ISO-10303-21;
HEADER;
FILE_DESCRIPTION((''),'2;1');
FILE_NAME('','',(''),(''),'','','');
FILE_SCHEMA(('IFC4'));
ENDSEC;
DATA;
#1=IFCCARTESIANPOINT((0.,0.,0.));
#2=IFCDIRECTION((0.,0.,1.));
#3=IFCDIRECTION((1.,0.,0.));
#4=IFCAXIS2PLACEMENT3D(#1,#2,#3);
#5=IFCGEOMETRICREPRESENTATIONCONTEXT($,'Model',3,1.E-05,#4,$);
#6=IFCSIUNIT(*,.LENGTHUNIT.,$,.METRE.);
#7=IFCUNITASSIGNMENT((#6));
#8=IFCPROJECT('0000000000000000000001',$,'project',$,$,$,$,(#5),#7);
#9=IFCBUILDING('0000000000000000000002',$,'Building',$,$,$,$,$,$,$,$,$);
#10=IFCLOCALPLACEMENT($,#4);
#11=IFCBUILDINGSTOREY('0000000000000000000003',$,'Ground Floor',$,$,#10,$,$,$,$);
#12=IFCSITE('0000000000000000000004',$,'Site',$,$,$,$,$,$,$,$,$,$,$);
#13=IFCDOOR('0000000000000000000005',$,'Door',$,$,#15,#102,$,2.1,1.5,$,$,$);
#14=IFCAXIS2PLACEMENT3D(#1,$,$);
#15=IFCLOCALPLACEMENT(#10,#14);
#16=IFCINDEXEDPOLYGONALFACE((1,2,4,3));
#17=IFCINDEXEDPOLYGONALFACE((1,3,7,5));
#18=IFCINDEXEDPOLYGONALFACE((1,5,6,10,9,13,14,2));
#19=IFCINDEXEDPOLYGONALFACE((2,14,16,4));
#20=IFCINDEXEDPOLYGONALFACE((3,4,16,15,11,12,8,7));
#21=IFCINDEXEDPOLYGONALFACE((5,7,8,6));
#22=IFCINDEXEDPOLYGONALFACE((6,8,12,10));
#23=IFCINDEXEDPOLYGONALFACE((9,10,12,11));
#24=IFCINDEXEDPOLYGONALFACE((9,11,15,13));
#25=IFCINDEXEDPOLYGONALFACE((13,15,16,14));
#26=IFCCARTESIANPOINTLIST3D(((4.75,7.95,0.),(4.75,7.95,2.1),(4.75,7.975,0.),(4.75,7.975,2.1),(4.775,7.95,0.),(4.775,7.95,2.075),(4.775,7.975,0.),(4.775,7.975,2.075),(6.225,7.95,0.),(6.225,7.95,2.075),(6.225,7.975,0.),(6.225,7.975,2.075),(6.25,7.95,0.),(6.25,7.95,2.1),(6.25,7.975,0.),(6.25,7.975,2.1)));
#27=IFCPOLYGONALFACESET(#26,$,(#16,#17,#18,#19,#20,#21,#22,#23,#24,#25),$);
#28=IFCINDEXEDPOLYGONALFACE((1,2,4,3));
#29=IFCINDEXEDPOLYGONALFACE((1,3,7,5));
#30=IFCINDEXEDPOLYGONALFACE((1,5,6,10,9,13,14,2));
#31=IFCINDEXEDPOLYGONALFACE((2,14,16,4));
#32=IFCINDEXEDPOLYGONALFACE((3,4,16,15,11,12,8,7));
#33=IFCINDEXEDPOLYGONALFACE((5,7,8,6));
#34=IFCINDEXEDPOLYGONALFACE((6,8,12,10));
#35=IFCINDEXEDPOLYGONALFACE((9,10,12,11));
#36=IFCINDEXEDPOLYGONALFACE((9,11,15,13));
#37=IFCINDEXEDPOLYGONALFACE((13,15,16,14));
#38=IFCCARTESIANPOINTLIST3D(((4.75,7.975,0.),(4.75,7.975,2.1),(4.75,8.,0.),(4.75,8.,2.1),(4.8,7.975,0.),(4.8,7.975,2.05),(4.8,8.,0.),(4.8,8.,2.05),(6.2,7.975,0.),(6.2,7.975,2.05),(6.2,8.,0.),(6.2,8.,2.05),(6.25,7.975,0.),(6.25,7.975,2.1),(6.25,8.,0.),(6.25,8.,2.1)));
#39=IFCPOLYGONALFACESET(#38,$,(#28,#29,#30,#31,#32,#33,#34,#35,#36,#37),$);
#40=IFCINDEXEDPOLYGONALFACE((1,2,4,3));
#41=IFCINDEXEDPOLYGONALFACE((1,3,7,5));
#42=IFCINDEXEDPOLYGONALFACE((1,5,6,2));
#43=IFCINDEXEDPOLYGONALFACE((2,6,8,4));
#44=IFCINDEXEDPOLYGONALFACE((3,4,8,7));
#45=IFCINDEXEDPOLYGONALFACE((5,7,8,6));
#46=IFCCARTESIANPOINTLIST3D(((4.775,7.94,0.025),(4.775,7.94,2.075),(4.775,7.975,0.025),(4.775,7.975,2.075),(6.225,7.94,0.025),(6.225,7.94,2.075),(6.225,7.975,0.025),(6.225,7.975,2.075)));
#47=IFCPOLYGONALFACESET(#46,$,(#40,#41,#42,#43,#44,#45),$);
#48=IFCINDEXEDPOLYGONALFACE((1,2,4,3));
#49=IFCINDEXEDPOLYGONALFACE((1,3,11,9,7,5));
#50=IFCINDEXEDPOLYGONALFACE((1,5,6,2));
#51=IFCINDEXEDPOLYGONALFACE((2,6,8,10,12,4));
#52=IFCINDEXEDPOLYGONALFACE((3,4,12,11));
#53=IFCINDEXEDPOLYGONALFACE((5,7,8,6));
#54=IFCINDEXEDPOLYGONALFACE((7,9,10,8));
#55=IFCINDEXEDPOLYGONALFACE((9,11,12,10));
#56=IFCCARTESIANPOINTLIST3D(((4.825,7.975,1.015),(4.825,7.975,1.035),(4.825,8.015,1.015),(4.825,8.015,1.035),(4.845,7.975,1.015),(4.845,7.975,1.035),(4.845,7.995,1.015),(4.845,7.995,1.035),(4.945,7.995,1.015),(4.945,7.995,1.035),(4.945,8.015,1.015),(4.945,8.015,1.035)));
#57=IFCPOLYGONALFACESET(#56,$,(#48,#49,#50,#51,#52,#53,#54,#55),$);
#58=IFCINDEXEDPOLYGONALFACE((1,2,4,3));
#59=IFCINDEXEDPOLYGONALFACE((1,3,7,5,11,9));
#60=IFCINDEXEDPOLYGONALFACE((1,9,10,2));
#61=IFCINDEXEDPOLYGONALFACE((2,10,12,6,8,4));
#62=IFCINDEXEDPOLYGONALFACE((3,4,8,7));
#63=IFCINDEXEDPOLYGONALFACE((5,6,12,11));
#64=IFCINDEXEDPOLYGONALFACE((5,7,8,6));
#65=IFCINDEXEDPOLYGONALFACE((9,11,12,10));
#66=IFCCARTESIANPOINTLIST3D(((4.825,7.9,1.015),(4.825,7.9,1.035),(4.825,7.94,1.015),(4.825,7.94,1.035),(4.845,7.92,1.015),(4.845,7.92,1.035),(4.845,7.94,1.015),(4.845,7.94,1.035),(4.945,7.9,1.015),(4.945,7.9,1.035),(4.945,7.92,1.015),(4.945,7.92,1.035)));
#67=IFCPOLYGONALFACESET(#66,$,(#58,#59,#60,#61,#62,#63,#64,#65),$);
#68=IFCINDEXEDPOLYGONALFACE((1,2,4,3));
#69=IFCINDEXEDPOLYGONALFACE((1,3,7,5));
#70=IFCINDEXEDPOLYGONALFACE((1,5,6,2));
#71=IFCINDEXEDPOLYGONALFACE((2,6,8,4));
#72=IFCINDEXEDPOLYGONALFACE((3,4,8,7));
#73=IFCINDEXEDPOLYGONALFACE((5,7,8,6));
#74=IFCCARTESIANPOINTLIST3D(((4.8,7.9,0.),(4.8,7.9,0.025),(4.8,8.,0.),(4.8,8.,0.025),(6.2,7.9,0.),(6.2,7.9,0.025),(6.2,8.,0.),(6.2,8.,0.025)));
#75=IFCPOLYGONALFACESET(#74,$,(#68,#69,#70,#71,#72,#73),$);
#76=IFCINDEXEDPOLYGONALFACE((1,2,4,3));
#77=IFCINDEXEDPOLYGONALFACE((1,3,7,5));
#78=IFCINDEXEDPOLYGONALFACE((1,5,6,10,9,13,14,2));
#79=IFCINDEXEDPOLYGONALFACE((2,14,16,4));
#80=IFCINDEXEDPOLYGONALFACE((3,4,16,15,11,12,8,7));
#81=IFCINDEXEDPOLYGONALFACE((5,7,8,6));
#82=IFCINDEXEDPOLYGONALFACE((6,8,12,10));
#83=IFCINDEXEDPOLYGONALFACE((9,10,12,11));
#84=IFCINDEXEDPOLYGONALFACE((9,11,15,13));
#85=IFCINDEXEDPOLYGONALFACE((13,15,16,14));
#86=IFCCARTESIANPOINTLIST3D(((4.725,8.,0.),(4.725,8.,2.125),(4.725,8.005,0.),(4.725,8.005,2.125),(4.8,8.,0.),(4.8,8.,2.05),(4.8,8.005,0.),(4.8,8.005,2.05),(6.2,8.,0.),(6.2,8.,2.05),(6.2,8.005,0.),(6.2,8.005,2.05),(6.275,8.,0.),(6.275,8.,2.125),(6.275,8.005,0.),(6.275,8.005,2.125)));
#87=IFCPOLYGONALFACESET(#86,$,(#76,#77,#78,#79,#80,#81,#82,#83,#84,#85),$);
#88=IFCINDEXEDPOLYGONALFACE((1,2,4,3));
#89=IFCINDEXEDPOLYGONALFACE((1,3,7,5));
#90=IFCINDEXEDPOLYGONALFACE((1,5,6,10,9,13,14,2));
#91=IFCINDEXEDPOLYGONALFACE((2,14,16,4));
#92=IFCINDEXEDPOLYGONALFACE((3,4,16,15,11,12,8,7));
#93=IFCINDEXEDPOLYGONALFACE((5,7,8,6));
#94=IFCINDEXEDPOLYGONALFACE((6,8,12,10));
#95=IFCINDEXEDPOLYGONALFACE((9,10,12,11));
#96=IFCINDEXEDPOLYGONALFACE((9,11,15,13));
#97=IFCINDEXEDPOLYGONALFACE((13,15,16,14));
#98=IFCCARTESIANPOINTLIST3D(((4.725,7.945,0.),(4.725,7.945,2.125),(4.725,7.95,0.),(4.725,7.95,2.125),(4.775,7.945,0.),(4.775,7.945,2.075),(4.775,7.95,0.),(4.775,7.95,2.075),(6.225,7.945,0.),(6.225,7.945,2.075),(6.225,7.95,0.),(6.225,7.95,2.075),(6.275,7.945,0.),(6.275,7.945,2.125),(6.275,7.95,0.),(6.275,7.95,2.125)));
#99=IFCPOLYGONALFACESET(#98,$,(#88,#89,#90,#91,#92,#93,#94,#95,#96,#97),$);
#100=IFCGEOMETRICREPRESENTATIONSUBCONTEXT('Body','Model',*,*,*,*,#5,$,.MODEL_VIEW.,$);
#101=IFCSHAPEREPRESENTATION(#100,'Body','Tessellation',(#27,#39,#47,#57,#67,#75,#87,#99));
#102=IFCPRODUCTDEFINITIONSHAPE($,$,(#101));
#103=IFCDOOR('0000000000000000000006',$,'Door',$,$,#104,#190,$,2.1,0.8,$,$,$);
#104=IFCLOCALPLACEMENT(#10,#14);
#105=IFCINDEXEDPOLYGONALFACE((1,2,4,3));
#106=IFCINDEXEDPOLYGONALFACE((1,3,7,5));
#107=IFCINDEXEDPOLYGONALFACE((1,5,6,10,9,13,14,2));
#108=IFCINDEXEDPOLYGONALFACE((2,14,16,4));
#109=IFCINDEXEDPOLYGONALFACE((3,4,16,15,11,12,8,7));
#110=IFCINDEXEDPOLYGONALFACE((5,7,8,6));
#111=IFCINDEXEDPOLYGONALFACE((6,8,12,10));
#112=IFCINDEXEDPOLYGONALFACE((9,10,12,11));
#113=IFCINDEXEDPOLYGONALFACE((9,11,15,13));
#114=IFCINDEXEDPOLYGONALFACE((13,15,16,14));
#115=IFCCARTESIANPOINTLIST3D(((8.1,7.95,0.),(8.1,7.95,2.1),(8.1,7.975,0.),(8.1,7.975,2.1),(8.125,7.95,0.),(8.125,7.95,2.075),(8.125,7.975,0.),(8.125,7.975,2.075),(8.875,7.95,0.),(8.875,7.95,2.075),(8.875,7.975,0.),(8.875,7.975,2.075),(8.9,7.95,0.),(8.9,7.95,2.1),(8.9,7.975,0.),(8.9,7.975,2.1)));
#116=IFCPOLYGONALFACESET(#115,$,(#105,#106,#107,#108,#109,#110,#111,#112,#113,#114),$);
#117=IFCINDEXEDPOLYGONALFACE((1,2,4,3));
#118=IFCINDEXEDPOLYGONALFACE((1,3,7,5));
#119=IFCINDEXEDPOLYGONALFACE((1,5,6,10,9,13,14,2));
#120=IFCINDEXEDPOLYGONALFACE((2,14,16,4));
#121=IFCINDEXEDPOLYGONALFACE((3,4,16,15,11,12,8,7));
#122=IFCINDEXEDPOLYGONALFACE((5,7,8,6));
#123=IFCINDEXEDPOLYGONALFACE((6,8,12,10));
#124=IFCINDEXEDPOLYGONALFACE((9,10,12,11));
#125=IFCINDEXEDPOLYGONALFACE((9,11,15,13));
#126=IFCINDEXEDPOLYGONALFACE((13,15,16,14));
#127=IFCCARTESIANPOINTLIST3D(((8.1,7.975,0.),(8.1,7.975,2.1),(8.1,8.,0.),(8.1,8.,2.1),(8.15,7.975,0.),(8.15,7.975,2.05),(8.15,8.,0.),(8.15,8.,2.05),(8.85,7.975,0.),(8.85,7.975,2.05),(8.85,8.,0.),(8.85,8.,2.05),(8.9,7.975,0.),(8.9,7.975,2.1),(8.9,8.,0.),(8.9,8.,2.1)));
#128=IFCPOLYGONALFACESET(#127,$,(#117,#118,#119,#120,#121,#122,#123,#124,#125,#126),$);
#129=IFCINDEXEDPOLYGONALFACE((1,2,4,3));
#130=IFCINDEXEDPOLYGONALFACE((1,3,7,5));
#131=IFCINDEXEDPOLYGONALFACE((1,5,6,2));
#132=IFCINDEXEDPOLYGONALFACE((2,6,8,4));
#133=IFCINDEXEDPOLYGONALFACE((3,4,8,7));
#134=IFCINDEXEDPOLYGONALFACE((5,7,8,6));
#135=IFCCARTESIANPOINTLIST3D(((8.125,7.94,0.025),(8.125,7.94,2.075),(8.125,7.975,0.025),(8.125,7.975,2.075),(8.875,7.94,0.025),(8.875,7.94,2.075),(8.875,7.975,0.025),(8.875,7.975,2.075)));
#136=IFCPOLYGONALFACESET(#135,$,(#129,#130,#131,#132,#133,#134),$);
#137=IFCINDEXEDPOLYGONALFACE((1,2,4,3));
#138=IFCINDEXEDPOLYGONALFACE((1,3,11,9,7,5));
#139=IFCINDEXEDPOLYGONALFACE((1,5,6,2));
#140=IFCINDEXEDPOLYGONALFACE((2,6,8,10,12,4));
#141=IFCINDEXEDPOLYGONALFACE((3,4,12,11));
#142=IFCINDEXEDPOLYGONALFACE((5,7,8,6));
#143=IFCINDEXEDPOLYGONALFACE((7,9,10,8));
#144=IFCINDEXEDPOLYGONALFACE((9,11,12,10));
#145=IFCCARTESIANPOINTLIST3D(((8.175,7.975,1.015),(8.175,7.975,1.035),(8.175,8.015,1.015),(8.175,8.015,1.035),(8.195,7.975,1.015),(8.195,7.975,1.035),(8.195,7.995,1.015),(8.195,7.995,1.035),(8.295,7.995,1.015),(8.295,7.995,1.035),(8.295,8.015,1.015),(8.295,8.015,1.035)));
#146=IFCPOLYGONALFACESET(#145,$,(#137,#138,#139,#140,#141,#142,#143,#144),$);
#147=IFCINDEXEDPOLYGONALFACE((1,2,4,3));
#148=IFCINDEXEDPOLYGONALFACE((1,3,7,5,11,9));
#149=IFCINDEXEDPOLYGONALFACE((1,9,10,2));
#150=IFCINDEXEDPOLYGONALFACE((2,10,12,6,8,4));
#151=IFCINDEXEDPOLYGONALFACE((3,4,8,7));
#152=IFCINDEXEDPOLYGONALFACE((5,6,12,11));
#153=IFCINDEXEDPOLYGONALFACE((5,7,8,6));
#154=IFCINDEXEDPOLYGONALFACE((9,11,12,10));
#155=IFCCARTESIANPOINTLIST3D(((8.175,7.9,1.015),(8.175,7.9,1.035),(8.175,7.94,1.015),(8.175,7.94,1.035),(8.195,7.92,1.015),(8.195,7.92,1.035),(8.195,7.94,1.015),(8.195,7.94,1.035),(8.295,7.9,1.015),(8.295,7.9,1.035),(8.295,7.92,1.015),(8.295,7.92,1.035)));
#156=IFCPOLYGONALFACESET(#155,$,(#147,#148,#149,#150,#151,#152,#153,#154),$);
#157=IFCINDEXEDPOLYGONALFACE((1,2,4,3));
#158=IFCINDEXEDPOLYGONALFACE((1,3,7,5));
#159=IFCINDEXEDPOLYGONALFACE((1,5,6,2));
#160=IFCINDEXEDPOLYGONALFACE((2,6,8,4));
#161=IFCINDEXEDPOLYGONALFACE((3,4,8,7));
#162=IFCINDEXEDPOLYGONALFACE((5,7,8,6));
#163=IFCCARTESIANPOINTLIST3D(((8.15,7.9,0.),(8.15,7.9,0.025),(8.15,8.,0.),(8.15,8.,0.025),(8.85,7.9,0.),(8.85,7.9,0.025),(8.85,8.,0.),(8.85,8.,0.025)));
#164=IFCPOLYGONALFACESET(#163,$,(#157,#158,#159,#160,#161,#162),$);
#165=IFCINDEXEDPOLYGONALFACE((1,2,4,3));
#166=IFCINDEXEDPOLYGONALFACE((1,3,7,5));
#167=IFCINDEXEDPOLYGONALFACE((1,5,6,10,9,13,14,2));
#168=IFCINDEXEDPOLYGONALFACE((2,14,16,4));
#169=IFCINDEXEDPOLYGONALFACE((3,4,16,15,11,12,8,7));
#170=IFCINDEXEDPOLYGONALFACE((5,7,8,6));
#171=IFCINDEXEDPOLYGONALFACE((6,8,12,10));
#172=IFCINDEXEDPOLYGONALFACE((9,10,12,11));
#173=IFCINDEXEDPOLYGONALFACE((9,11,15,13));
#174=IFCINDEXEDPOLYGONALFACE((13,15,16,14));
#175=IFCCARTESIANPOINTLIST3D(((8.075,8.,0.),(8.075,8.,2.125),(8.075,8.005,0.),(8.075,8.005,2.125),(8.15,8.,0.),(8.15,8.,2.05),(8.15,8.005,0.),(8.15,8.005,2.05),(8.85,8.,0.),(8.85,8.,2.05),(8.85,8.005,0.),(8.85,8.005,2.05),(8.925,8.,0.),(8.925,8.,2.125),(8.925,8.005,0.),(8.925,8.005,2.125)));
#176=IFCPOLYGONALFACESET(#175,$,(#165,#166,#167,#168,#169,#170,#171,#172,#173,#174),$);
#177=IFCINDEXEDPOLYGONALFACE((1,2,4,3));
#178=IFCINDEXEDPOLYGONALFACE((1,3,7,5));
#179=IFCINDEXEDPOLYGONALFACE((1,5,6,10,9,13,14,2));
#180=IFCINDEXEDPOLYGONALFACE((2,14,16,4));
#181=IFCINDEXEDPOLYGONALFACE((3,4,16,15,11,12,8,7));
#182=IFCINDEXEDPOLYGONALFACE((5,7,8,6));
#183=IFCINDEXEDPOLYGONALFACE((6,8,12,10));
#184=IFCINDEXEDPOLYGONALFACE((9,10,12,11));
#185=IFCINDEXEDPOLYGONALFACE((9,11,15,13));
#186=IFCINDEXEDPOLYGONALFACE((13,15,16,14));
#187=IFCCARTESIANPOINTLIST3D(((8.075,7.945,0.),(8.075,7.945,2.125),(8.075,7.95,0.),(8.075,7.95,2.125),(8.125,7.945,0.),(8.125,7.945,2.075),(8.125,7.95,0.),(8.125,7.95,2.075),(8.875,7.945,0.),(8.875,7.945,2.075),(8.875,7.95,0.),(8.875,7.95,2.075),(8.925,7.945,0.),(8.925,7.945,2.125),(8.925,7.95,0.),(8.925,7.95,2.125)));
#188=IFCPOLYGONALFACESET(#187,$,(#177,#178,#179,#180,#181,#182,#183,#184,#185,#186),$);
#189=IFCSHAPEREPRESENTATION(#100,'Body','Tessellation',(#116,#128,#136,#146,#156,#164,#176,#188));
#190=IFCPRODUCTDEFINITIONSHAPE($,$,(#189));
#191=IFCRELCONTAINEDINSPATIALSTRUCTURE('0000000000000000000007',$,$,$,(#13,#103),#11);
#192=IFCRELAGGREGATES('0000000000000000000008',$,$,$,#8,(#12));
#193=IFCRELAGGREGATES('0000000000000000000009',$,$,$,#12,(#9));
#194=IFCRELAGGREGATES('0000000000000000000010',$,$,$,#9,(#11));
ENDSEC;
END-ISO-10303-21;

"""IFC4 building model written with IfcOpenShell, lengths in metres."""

from ifc_helpers import new_model, si_unit, frame, origin_with_axes, place, context, subcontext, project, spatial, line, indexed_curve, outline, extrude, element, save


model = new_model("IFC4")

# Units and contexts
model_context = context("Model", 3, precision=1e-05, world=origin_with_axes())
body_context = subcontext(model_context, "Body", "Model", "MODEL_VIEW")
ifc_project = project(units=[si_unit("LENGTHUNIT", "METRE")], contexts=[model_context])

# Site, building, storey
site = spatial("IfcSite", under=ifc_project, Name="Site")
building = spatial("IfcBuilding", under=site, Name="Building")
storey_placement = place(None, origin_with_axes())
storey = spatial("IfcBuildingStorey", under=building, at=storey_placement, Name="Ground Floor")

# Doors
door_1_placement = place(storey_placement, frame((6.25, 8.0, 0.0), z_axis=(0.0, 0.0, 1.0), x_axis=(-1.0, 0.0, 0.0)))
element("IfcDoor", 1, at=door_1_placement, inside=storey, Name="Door", OverallHeight=2.1, OverallWidth=1.5, context=body_context, shape_type="SweptSolid", body=[
    extrude(outline(indexed_curve([(0.0, 0.0), (0.0, 2.1), (1.5, 2.1), (1.5, 0.0), (1.475, 0.0), (1.475, 2.075), (0.025, 2.075), (0.025, 0.0)], segments=[line(1, 2, 3, 4, 5, 6, 7, 8, 1)])), frame((0.0, 0.025, 0.0), z_axis=(0.0, -1.0, 0.0), x_axis=(1.0, 0.0, 0.0)), (0.0, 0.0, -1.0), 0.025),
    extrude(outline(indexed_curve([(0.0, 0.0), (0.0, 2.1), (1.5, 2.1), (1.5, 0.0), (1.45, 0.0), (1.45, 2.05), (0.05, 2.05), (0.05, 0.0)], segments=[line(1, 2, 3, 4, 5, 6, 7, 8, 1)])), frame((0.0, 0.0, 0.0), z_axis=(0.0, -1.0, 0.0), x_axis=(1.0, 0.0, 0.0)), (0.0, 0.0, -1.0), 0.025),
    extrude(outline(indexed_curve([(0.0, 0.0), (1.45, 0.0), (1.45, 0.035), (0.0, 0.035)], segments=[line(1, 2, 3, 4, 1)])), frame((0.025, 0.025, 0.025), z_axis=(0.0, 0.0, 1.0), x_axis=(1.0, 0.0, 0.0)), (0.0, 0.0, 1.0), 2.05),
    extrude(outline(indexed_curve([(0.0, 0.0), (0.0, -0.04), (-0.12, -0.04), (-0.12, -0.02), (-0.02, -0.02), (-0.02, 0.0)], segments=[line(1, 2, 3, 4, 5, 6, 1)])), frame((1.425, 0.025, 1.015), z_axis=(0.0, 0.0, 1.0), x_axis=(1.0, 0.0, 0.0)), (0.0, 0.0, 1.0), 0.02),
    extrude(outline(indexed_curve([(0.0, 0.0), (0.0, 0.04), (-0.12, 0.04), (-0.12, 0.02), (-0.02, 0.02), (-0.02, 0.0)], segments=[line(1, 2, 3, 4, 5, 6, 1)])), frame((1.425, 0.06, 1.015), z_axis=(0.0, 0.0, 1.0), x_axis=(1.0, 0.0, 0.0)), (0.0, 0.0, 1.0), 0.02),
    extrude(outline(indexed_curve([(0.0, 0.0), (1.4, 0.0), (1.4, 0.1), (0.0, 0.1)], segments=[line(1, 2, 3, 4, 1)])), frame((0.05, 0.0, 0.0), z_axis=(0.0, 0.0, 1.0), x_axis=(1.0, 0.0, 0.0)), (0.0, 0.0, 1.0), 0.025),
    extrude(outline(indexed_curve([(0.0, 0.0), (0.0, 2.125), (1.55, 2.125), (1.55, 0.0), (1.475, 0.0), (1.475, 2.05), (0.075, 2.05), (0.075, 0.0)], segments=[line(1, 2, 3, 4, 5, 6, 7, 8, 1)])), frame((-0.025, -0.005, 0.0), z_axis=(0.0, -1.0, 0.0), x_axis=(1.0, 0.0, 0.0)), (0.0, 0.0, -1.0), 0.005),
    extrude(outline(indexed_curve([(0.0, 0.0), (0.0, 2.125), (1.55, 2.125), (1.55, 0.0), (1.5, 0.0), (1.5, 2.075), (0.05, 2.075), (0.05, 0.0)], segments=[line(1, 2, 3, 4, 5, 6, 7, 8, 1)])), frame((-0.025, 0.05, 0.0), z_axis=(0.0, -1.0, 0.0), x_axis=(1.0, 0.0, 0.0)), (0.0, 0.0, -1.0), 0.005),
])
door_2_placement = place(storey_placement, frame((8.9, 8.0, 0.0), z_axis=(0.0, 0.0, 1.0), x_axis=(-1.0, 0.0, 0.0)))
element("IfcDoor", 2, at=door_2_placement, inside=storey, Name="Door", OverallHeight=2.1, OverallWidth=0.8, context=body_context, shape_type="SweptSolid", body=[
    extrude(outline(indexed_curve([(0.0, 0.0), (0.0, 2.1), (0.8, 2.1), (0.8, 0.0), (0.775, 0.0), (0.775, 2.075), (0.025, 2.075), (0.025, 0.0)], segments=[line(1, 2, 3, 4, 5, 6, 7, 8, 1)])), frame((0.0, 0.025, 0.0), z_axis=(0.0, -1.0, 0.0), x_axis=(1.0, 0.0, 0.0)), (0.0, 0.0, -1.0), 0.025),
    extrude(outline(indexed_curve([(0.0, 0.0), (0.0, 2.1), (0.8, 2.1), (0.8, 0.0), (0.75, 0.0), (0.75, 2.05), (0.05, 2.05), (0.05, 0.0)], segments=[line(1, 2, 3, 4, 5, 6, 7, 8, 1)])), frame((0.0, 0.0, 0.0), z_axis=(0.0, -1.0, 0.0), x_axis=(1.0, 0.0, 0.0)), (0.0, 0.0, -1.0), 0.025),
    extrude(outline(indexed_curve([(0.0, 0.0), (0.75, 0.0), (0.75, 0.035), (0.0, 0.035)], segments=[line(1, 2, 3, 4, 1)])), frame((0.025, 0.025, 0.025), z_axis=(0.0, 0.0, 1.0), x_axis=(1.0, 0.0, 0.0)), (0.0, 0.0, 1.0), 2.05),
    extrude(outline(indexed_curve([(0.0, 0.0), (0.0, -0.04), (-0.12, -0.04), (-0.12, -0.02), (-0.02, -0.02), (-0.02, 0.0)], segments=[line(1, 2, 3, 4, 5, 6, 1)])), frame((0.725, 0.025, 1.015), z_axis=(0.0, 0.0, 1.0), x_axis=(1.0, 0.0, 0.0)), (0.0, 0.0, 1.0), 0.02),
    extrude(outline(indexed_curve([(0.0, 0.0), (0.0, 0.04), (-0.12, 0.04), (-0.12, 0.02), (-0.02, 0.02), (-0.02, 0.0)], segments=[line(1, 2, 3, 4, 5, 6, 1)])), frame((0.725, 0.06, 1.015), z_axis=(0.0, 0.0, 1.0), x_axis=(1.0, 0.0, 0.0)), (0.0, 0.0, 1.0), 0.02),
    extrude(outline(indexed_curve([(0.0, 0.0), (0.7, 0.0), (0.7, 0.1), (0.0, 0.1)], segments=[line(1, 2, 3, 4, 1)])), frame((0.05, 0.0, 0.0), z_axis=(0.0, 0.0, 1.0), x_axis=(1.0, 0.0, 0.0)), (0.0, 0.0, 1.0), 0.025),
    extrude(outline(indexed_curve([(0.0, 0.0), (0.0, 2.125), (0.85, 2.125), (0.85, 0.0), (0.775, 0.0), (0.775, 2.05), (0.075, 2.05), (0.075, 0.0)], segments=[line(1, 2, 3, 4, 5, 6, 7, 8, 1)])), frame((-0.025, -0.005, 0.0), z_axis=(0.0, -1.0, 0.0), x_axis=(1.0, 0.0, 0.0)), (0.0, 0.0, -1.0), 0.005),
    extrude(outline(indexed_curve([(0.0, 0.0), (0.0, 2.125), (0.85, 2.125), (0.85, 0.0), (0.8, 0.0), (0.8, 2.075), (0.05, 2.075), (0.05, 0.0)], segments=[line(1, 2, 3, 4, 5, 6, 7, 8, 1)])), frame((-0.025, 0.05, 0.0), z_axis=(0.0, -1.0, 0.0), x_axis=(1.0, 0.0, 0.0)), (0.0, 0.0, -1.0), 0.005),
])

save(model, "model.ifc")
